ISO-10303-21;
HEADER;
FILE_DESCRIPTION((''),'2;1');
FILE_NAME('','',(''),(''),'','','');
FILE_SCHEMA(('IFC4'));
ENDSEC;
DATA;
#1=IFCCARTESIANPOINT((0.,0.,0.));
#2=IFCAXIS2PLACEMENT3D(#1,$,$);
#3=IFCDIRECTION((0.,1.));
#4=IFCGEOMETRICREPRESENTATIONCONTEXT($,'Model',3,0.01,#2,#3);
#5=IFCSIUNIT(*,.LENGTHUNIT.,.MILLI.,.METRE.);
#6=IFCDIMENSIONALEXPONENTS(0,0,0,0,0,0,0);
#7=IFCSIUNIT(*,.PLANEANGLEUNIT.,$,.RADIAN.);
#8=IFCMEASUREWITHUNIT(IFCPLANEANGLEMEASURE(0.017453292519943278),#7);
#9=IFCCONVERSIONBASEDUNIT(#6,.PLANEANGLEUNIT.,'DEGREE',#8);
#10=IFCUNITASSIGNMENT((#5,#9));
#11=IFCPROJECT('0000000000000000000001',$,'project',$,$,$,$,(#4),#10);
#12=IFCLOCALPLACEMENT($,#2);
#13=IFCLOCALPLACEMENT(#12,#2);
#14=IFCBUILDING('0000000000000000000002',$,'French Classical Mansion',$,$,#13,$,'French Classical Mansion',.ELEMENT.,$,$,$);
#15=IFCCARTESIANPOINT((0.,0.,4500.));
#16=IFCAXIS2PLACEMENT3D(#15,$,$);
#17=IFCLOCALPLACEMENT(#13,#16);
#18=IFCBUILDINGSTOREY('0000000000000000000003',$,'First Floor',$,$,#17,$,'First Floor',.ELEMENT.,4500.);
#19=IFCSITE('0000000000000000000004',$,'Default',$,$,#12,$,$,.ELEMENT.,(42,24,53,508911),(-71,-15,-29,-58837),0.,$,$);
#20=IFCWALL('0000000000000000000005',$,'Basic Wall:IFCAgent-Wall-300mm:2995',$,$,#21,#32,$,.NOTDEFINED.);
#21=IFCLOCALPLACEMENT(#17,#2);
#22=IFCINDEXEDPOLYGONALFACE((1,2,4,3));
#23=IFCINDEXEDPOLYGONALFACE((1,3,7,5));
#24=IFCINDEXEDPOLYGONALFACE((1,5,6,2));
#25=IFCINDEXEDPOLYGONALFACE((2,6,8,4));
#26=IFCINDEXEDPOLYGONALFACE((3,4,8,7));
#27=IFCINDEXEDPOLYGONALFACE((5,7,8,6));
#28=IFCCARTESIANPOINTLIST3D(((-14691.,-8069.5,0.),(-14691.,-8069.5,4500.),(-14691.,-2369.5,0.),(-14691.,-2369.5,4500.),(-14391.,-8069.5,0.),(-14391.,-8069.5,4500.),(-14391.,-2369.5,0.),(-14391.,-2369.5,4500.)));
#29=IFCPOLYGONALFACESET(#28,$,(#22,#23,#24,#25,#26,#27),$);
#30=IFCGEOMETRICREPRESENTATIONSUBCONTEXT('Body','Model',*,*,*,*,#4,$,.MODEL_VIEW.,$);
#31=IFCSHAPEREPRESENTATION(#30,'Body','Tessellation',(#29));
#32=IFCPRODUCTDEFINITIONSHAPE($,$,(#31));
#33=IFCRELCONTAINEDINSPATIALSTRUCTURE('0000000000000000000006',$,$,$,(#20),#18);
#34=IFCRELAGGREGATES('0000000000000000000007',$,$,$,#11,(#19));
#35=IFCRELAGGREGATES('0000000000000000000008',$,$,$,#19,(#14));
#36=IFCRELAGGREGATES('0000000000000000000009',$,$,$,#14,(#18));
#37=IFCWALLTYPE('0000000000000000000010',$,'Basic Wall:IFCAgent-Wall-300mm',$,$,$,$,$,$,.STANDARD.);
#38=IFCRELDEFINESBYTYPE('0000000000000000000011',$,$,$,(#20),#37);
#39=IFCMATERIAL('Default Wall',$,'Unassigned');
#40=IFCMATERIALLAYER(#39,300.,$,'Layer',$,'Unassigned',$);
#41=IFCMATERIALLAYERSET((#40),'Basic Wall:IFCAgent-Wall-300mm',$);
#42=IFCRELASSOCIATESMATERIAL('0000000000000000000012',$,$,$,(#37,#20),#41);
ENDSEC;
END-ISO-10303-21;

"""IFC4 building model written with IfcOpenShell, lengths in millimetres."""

from ifc_helpers import new_model, entity, si_unit, converted_unit, direction, frame, frame_2d, origin, place, context, subcontext, project, spatial, rectangle, extrude, material, layer, layer_set, layer_usage, type_object, element, save


model = new_model("IFC4")

# Units and contexts
model_context = context("Model", 3, precision=0.01, world=origin(), true_north=direction((0.0, 1.0)))
body_context = subcontext(model_context, "Body", "Model", "MODEL_VIEW")
ifc_project = project(units=[si_unit("LENGTHUNIT", "METRE", prefix="MILLI"), converted_unit("PLANEANGLEUNIT", "DEGREE", entity("IfcPlaneAngleMeasure", 0.017453292519943278), si_unit("PLANEANGLEUNIT", "RADIAN"), dimensions=[0, 0, 0, 0, 0, 0, 0])], contexts=[model_context])

# Site, building, storey
site_placement = place(None, origin())
site = spatial("IfcSite", under=ifc_project, at=site_placement, Name="Default", CompositionType="ELEMENT", RefLatitude=(42, 24, 53, 508911), RefLongitude=(-71, -15, -29, -58837), RefElevation=0.0)
building_placement = place(site_placement, origin())
building = spatial("IfcBuilding", under=site, at=building_placement, Name="French Classical Mansion", LongName="French Classical Mansion", CompositionType="ELEMENT")
storey_placement = place(building_placement, frame((0.0, 0.0, 4500.0)))
storey = spatial("IfcBuildingStorey", under=building, at=storey_placement, Name="First Floor", LongName="First Floor", CompositionType="ELEMENT", Elevation=4500.0)

# Shared definitions
ifc_material = material(Name="Default Wall", Category="Unassigned")
ifc_layer = layer(ifc_material, 300.0, Name="Layer", Category="Unassigned")
ifc_layer_set = layer_set([ifc_layer], Name="Basic Wall:IFCAgent-Wall-300mm")
wall_type = type_object("IfcWallType", Name="Basic Wall:IFCAgent-Wall-300mm", PredefinedType="STANDARD", material=ifc_layer_set)

# Wall
ifc_layer_usage_1 = layer_usage(ifc_layer_set, "AXIS2", "NEGATIVE", 150.0)
wall_1_placement = place(storey_placement, frame((-14541.0, -2369.5, 0.0), z_axis=(0.0, 0.0, 1.0), x_axis=(0.0, -1.0, 0.0)))
element("IfcWall", 1, at=wall_1_placement, inside=storey, type_object=wall_type, material=ifc_layer_usage_1, Name="Basic Wall:IFCAgent-Wall-300mm:2995", PredefinedType="NOTDEFINED", context=body_context, shape_type="SweptSolid", body=[
    extrude(rectangle(XDim=5700.0, YDim=300.0, at=frame_2d((2850.0, 0.0), x_axis=(-1.0, 0.0))), origin(), (0.0, 0.0, 1.0), 4500.0),
])

save(model, "model.ifc")
